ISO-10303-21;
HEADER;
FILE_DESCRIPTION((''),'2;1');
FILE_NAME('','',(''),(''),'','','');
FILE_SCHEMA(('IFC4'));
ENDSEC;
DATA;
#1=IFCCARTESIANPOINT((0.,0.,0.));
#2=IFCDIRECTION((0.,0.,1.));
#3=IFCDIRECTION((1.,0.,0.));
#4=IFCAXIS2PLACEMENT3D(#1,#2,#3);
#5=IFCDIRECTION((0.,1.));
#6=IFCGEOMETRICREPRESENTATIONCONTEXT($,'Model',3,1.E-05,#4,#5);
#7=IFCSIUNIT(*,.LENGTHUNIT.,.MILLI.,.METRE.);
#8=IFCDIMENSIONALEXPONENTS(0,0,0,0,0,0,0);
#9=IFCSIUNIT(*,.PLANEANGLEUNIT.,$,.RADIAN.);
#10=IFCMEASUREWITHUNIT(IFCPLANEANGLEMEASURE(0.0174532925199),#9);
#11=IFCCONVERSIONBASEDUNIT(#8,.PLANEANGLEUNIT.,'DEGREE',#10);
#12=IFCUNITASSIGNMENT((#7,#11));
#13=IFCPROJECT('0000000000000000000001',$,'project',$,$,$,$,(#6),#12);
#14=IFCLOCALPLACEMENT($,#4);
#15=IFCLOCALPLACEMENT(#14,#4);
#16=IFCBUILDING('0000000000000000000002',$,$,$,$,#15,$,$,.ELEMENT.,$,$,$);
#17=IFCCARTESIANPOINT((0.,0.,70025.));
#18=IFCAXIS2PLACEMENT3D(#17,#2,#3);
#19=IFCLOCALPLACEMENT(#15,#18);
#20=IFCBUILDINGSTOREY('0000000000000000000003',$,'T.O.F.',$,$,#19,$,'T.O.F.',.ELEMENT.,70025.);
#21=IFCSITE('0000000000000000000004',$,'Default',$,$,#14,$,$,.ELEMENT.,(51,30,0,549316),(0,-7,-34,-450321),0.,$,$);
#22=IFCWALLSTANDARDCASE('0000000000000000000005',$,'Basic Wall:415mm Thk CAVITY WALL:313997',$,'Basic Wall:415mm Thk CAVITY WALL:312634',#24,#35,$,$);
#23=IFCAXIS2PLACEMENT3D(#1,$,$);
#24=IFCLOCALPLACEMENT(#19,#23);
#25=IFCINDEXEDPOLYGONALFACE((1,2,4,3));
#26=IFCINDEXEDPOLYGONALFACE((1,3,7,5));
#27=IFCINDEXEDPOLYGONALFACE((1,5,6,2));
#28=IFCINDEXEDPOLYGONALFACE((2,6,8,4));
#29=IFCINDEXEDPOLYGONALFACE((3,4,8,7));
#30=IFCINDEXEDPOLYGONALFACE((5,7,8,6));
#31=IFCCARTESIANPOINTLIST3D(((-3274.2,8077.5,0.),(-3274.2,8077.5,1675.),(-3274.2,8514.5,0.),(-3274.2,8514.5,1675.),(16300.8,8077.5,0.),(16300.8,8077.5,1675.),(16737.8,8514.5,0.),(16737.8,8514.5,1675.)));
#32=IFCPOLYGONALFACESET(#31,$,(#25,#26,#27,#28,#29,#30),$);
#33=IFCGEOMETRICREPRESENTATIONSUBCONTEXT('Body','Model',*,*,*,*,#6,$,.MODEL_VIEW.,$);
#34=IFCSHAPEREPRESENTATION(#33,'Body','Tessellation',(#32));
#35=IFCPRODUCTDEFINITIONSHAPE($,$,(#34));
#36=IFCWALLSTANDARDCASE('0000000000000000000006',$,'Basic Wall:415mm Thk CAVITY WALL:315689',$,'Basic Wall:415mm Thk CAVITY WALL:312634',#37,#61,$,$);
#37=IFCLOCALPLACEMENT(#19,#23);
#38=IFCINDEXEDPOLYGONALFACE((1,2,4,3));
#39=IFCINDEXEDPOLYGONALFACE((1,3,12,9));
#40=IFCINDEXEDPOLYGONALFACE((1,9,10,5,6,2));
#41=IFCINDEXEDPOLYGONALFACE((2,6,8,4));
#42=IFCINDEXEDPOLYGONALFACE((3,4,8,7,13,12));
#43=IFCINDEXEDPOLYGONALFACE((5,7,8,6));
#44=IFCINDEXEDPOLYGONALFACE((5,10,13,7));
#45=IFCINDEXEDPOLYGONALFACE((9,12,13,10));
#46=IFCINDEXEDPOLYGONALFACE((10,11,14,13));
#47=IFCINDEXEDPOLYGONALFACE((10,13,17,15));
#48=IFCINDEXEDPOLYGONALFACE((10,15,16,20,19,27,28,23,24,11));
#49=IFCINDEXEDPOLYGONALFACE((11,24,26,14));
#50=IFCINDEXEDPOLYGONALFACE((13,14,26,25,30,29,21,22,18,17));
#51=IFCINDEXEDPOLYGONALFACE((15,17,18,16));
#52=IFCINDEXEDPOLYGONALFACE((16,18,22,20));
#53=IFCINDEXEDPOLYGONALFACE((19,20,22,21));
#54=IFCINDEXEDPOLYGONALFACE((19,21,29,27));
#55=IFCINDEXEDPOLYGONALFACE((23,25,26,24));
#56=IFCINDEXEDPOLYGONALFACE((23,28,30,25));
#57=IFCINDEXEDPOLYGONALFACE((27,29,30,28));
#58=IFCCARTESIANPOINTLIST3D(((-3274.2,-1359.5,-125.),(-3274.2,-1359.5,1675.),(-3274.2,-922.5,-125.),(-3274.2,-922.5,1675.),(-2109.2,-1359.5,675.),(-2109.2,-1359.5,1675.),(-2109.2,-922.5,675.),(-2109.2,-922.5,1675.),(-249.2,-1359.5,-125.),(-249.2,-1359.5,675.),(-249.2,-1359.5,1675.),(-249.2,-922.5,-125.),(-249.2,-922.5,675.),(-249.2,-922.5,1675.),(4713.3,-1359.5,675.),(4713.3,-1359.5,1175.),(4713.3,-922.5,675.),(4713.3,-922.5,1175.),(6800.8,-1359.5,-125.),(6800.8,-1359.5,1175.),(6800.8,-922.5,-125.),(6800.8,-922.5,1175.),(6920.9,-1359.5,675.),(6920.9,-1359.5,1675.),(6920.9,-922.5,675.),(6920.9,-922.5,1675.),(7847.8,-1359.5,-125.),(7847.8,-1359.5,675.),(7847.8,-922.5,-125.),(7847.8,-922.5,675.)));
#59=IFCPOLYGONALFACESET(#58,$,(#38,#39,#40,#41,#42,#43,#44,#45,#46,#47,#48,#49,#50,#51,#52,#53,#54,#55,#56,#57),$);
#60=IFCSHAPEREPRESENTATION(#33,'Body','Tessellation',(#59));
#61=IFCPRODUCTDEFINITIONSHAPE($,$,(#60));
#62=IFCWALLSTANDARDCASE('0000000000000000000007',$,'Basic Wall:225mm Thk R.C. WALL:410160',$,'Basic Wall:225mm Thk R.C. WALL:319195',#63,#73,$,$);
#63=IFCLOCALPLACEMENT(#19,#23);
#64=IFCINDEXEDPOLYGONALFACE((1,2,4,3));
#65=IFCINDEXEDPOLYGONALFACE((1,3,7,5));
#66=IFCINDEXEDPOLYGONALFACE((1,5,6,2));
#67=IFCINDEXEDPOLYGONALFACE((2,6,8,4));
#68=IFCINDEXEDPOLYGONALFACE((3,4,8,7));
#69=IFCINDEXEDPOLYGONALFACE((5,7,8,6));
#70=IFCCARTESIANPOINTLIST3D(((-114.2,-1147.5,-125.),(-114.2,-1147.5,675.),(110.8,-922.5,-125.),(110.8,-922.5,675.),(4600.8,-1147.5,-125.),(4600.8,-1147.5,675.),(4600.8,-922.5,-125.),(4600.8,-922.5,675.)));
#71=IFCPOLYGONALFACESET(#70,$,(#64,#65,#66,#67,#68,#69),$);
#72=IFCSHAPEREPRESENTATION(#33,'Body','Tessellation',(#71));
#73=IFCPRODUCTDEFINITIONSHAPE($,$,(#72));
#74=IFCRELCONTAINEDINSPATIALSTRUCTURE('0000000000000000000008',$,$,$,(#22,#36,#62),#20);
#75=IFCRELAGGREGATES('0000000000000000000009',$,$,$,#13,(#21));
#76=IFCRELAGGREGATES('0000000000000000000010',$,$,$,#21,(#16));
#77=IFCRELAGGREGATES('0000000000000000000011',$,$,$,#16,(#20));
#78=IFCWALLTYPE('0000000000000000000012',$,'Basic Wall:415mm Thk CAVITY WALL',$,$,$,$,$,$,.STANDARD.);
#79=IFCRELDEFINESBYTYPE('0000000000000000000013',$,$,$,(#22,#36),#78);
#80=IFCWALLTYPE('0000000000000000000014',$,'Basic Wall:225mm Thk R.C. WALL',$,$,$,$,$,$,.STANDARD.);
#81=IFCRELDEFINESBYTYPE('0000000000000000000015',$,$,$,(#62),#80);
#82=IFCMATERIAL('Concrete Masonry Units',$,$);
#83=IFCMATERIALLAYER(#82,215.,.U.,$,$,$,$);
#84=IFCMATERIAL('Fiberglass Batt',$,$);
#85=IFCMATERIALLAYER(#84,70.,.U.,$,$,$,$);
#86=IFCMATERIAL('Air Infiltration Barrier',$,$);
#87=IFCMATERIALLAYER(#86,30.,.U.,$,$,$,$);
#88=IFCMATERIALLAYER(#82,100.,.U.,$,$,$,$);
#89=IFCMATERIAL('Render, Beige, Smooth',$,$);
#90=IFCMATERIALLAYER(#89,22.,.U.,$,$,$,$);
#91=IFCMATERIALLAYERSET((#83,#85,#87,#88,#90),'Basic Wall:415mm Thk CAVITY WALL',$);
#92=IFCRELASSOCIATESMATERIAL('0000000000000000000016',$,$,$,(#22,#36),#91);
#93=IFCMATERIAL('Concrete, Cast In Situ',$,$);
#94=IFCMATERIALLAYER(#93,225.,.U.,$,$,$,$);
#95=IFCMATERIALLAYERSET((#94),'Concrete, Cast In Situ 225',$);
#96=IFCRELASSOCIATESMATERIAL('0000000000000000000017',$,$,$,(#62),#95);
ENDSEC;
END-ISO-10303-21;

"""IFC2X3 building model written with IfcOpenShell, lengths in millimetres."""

from ifc_helpers import new_model, entity, si_unit, converted_unit, direction, frame, origin_with_axes, place, context, subcontext, project, spatial, polyline, outline, extrude, material, layer, layer_set, layer_usage, type_object, element, save


model = new_model("IFC2X3")

# Units and contexts
model_context = context("Model", 3, precision=1e-05, world=origin_with_axes(), true_north=direction((0.0, 1.0)))
body_context = subcontext(model_context, "Body", "Model", "MODEL_VIEW")
ifc_project = project(units=[si_unit("LENGTHUNIT", "METRE", prefix="MILLI"), converted_unit("PLANEANGLEUNIT", "DEGREE", entity("IfcPlaneAngleMeasure", 0.0174532925199), si_unit("PLANEANGLEUNIT", "RADIAN"), dimensions=[0, 0, 0, 0, 0, 0, 0])], contexts=[model_context])

# Site, building, storey
site_placement = place(None, origin_with_axes())
site = spatial("IfcSite", under=ifc_project, at=site_placement, Name="Default", CompositionType="ELEMENT", RefLatitude=(51, 30, 0, 549316), RefLongitude=(0, -7, -34, -450321), RefElevation=0.0)
building_placement = place(site_placement, origin_with_axes())
building = spatial("IfcBuilding", under=site, at=building_placement, CompositionType="ELEMENT")
storey_placement = place(building_placement, frame((0.0, 0.0, 70025.0), z_axis=(0.0, 0.0, 1.0), x_axis=(1.0, 0.0, 0.0)))
storey = spatial("IfcBuildingStorey", under=building, at=storey_placement, Name="T.O.F.", LongName="T.O.F.", CompositionType="ELEMENT", Elevation=70025.0)

# Shared definitions
ifc_material_1 = material(Name="Concrete Masonry Units")

# Wall
ifc_layer_1 = layer(ifc_material_1, 215.0, ventilated="UNKNOWN")
ifc_material_2 = material(Name="Fiberglass Batt")
ifc_layer_2 = layer(ifc_material_2, 70.0, ventilated="UNKNOWN")
ifc_material_3 = material(Name="Air Infiltration Barrier")
ifc_layer_3 = layer(ifc_material_3, 30.0, ventilated="UNKNOWN")
ifc_layer_4 = layer(ifc_material_1, 100.0, ventilated="UNKNOWN")
ifc_material_4 = material(Name="Render, Beige, Smooth")
ifc_layer_5 = layer(ifc_material_4, 22.0, ventilated="UNKNOWN")
ifc_layer_set_1 = layer_set([ifc_layer_1, ifc_layer_2, ifc_layer_3, ifc_layer_4, ifc_layer_5], Name="Basic Wall:415mm Thk CAVITY WALL")
ifc_layer_usage_1 = layer_usage(ifc_layer_set_1, "AXIS2", "POSITIVE", -218.5)
wall_type_1 = type_object("IfcWallType", Name="Basic Wall:415mm Thk CAVITY WALL", PredefinedType="STANDARD")
wall_1_placement = place(storey_placement, frame((-3274.2, 8296.0, 0.0), z_axis=(0.0, 0.0, 1.0), x_axis=(1.0, 0.0, 0.0)))
element("IfcWallStandardCase", 1, at=wall_1_placement, inside=storey, type_object=wall_type_1, material=ifc_layer_usage_1, Name="Basic Wall:415mm Thk CAVITY WALL:313997", ObjectType="Basic Wall:415mm Thk CAVITY WALL:312634", context=body_context, shape_type="SweptSolid", body=[
    extrude(outline(polyline([(0.0, -218.5), (19575.0, -218.5), (20012.0, 218.5), (0.0, 218.5), (0.0, -218.5)])), origin_with_axes(), (0.0, 0.0, 1.0), 1675.0),
])

# Wall, openings
ifc_layer_usage_2 = layer_usage(ifc_layer_set_1, "AXIS2", "POSITIVE", -218.5)
wall_2_placement = place(storey_placement, frame((7847.8, -1141.0, -125.0), z_axis=(0.0, 0.0, 1.0), x_axis=(-1.0, 0.0, 0.0)))
wall_2 = element("IfcWallStandardCase", 2, at=wall_2_placement, inside=storey, type_object=wall_type_1, material=ifc_layer_usage_2, Name="Basic Wall:415mm Thk CAVITY WALL:315689", ObjectType="Basic Wall:415mm Thk CAVITY WALL:312634", context=body_context, shape_type="SweptSolid", body=[
    extrude(outline(polyline([(0.0, -218.5), (11122.0, -218.5), (11122.0, 218.5), (0.0, 218.5), (0.0, -218.5)])), origin_with_axes(), (0.0, 0.0, 1.0), 1800.0),
])
opening_1_placement = place(wall_2_placement, frame((-3.1, 0.0, 800.0), z_axis=(0.0, 0.0, 1.0), x_axis=(1.0, 0.0, 0.0)))
element("IfcOpeningElement", 3, at=opening_1_placement, cuts=wall_2, context=body_context, shape_type="SweptSolid", body=[
    extrude(outline(polyline([(930.0, 0.0), (-930.0, 0.0), (-930.0, -2100.0), (930.0, -2100.0), (930.0, 0.0)])), frame((0.0, -1742.5, 0.0), z_axis=(0.0, 1.0, 0.0), x_axis=(1.0, 0.0, 0.0)), (0.0, 0.0, 1.0), 3048.0),
])
opening_2_placement = place(wall_2_placement, frame((4572.0, 0.0, 0.0), z_axis=(0.0, 0.0, 1.0), x_axis=(1.0, 0.0, 0.0)))
element("IfcOpeningElement", 4, at=opening_2_placement, cuts=wall_2, context=body_context, shape_type="SweptSolid", body=[
    extrude(outline(polyline([(-3525.0, 0.0), (3525.0, 0.0), (3525.0, 800.0), (-1437.5, 800.0), (-1437.5, 1300.0), (-3525.0, 1300.0), (-3525.0, 0.0)])), frame((0.0, 218.5, 0.0), z_axis=(0.0, -1.0, 0.0), x_axis=(1.0, 0.0, 0.0)), (0.0, 0.0, 1.0), 437.0),
])
opening_3_placement = place(wall_2_placement, frame((9027.0, 0.0, 800.0), z_axis=(0.0, 0.0, 1.0), x_axis=(1.0, 0.0, 0.0)))
element("IfcOpeningElement", 5, at=opening_3_placement, cuts=wall_2, context=body_context, shape_type="SweptSolid", body=[
    extrude(outline(polyline([(930.0, 0.0), (-930.0, 0.0), (-930.0, -2100.0), (930.0, -2100.0), (930.0, 0.0)])), frame((0.0, -218.5, 0.0), z_axis=(0.0, 1.0, 0.0), x_axis=(1.0, 0.0, 0.0)), (0.0, 0.0, 1.0), 437.0),
])

# Wall
ifc_material_5 = material(Name="Concrete, Cast In Situ")
ifc_layer_6 = layer(ifc_material_5, 225.0, ventilated="UNKNOWN")
ifc_layer_set_2 = layer_set([ifc_layer_6], Name="Concrete, Cast In Situ 225")
wall_type_2 = type_object("IfcWallType", Name="Basic Wall:225mm Thk R.C. WALL", PredefinedType="STANDARD")
ifc_layer_usage_3 = layer_usage(ifc_layer_set_2, "AXIS2", "POSITIVE", -112.5)
wall_3_placement = place(storey_placement, frame((4713.3, -1035.0, -125.0), z_axis=(0.0, 0.0, 1.0), x_axis=(-1.0, 0.0, 0.0)))
element("IfcWallStandardCase", 6, at=wall_3_placement, inside=storey, type_object=wall_type_2, material=ifc_layer_usage_3, Name="Basic Wall:225mm Thk R.C. WALL:410160", ObjectType="Basic Wall:225mm Thk R.C. WALL:319195", context=body_context, shape_type="SweptSolid", body=[
    extrude(outline(polyline([(112.5, -112.5), (4602.5, -112.5), (4827.5, 112.5), (112.5, 112.5), (112.5, -112.5)])), origin_with_axes(), (0.0, 0.0, 1.0), 800.0),
])

save(model, "model.ifc")
